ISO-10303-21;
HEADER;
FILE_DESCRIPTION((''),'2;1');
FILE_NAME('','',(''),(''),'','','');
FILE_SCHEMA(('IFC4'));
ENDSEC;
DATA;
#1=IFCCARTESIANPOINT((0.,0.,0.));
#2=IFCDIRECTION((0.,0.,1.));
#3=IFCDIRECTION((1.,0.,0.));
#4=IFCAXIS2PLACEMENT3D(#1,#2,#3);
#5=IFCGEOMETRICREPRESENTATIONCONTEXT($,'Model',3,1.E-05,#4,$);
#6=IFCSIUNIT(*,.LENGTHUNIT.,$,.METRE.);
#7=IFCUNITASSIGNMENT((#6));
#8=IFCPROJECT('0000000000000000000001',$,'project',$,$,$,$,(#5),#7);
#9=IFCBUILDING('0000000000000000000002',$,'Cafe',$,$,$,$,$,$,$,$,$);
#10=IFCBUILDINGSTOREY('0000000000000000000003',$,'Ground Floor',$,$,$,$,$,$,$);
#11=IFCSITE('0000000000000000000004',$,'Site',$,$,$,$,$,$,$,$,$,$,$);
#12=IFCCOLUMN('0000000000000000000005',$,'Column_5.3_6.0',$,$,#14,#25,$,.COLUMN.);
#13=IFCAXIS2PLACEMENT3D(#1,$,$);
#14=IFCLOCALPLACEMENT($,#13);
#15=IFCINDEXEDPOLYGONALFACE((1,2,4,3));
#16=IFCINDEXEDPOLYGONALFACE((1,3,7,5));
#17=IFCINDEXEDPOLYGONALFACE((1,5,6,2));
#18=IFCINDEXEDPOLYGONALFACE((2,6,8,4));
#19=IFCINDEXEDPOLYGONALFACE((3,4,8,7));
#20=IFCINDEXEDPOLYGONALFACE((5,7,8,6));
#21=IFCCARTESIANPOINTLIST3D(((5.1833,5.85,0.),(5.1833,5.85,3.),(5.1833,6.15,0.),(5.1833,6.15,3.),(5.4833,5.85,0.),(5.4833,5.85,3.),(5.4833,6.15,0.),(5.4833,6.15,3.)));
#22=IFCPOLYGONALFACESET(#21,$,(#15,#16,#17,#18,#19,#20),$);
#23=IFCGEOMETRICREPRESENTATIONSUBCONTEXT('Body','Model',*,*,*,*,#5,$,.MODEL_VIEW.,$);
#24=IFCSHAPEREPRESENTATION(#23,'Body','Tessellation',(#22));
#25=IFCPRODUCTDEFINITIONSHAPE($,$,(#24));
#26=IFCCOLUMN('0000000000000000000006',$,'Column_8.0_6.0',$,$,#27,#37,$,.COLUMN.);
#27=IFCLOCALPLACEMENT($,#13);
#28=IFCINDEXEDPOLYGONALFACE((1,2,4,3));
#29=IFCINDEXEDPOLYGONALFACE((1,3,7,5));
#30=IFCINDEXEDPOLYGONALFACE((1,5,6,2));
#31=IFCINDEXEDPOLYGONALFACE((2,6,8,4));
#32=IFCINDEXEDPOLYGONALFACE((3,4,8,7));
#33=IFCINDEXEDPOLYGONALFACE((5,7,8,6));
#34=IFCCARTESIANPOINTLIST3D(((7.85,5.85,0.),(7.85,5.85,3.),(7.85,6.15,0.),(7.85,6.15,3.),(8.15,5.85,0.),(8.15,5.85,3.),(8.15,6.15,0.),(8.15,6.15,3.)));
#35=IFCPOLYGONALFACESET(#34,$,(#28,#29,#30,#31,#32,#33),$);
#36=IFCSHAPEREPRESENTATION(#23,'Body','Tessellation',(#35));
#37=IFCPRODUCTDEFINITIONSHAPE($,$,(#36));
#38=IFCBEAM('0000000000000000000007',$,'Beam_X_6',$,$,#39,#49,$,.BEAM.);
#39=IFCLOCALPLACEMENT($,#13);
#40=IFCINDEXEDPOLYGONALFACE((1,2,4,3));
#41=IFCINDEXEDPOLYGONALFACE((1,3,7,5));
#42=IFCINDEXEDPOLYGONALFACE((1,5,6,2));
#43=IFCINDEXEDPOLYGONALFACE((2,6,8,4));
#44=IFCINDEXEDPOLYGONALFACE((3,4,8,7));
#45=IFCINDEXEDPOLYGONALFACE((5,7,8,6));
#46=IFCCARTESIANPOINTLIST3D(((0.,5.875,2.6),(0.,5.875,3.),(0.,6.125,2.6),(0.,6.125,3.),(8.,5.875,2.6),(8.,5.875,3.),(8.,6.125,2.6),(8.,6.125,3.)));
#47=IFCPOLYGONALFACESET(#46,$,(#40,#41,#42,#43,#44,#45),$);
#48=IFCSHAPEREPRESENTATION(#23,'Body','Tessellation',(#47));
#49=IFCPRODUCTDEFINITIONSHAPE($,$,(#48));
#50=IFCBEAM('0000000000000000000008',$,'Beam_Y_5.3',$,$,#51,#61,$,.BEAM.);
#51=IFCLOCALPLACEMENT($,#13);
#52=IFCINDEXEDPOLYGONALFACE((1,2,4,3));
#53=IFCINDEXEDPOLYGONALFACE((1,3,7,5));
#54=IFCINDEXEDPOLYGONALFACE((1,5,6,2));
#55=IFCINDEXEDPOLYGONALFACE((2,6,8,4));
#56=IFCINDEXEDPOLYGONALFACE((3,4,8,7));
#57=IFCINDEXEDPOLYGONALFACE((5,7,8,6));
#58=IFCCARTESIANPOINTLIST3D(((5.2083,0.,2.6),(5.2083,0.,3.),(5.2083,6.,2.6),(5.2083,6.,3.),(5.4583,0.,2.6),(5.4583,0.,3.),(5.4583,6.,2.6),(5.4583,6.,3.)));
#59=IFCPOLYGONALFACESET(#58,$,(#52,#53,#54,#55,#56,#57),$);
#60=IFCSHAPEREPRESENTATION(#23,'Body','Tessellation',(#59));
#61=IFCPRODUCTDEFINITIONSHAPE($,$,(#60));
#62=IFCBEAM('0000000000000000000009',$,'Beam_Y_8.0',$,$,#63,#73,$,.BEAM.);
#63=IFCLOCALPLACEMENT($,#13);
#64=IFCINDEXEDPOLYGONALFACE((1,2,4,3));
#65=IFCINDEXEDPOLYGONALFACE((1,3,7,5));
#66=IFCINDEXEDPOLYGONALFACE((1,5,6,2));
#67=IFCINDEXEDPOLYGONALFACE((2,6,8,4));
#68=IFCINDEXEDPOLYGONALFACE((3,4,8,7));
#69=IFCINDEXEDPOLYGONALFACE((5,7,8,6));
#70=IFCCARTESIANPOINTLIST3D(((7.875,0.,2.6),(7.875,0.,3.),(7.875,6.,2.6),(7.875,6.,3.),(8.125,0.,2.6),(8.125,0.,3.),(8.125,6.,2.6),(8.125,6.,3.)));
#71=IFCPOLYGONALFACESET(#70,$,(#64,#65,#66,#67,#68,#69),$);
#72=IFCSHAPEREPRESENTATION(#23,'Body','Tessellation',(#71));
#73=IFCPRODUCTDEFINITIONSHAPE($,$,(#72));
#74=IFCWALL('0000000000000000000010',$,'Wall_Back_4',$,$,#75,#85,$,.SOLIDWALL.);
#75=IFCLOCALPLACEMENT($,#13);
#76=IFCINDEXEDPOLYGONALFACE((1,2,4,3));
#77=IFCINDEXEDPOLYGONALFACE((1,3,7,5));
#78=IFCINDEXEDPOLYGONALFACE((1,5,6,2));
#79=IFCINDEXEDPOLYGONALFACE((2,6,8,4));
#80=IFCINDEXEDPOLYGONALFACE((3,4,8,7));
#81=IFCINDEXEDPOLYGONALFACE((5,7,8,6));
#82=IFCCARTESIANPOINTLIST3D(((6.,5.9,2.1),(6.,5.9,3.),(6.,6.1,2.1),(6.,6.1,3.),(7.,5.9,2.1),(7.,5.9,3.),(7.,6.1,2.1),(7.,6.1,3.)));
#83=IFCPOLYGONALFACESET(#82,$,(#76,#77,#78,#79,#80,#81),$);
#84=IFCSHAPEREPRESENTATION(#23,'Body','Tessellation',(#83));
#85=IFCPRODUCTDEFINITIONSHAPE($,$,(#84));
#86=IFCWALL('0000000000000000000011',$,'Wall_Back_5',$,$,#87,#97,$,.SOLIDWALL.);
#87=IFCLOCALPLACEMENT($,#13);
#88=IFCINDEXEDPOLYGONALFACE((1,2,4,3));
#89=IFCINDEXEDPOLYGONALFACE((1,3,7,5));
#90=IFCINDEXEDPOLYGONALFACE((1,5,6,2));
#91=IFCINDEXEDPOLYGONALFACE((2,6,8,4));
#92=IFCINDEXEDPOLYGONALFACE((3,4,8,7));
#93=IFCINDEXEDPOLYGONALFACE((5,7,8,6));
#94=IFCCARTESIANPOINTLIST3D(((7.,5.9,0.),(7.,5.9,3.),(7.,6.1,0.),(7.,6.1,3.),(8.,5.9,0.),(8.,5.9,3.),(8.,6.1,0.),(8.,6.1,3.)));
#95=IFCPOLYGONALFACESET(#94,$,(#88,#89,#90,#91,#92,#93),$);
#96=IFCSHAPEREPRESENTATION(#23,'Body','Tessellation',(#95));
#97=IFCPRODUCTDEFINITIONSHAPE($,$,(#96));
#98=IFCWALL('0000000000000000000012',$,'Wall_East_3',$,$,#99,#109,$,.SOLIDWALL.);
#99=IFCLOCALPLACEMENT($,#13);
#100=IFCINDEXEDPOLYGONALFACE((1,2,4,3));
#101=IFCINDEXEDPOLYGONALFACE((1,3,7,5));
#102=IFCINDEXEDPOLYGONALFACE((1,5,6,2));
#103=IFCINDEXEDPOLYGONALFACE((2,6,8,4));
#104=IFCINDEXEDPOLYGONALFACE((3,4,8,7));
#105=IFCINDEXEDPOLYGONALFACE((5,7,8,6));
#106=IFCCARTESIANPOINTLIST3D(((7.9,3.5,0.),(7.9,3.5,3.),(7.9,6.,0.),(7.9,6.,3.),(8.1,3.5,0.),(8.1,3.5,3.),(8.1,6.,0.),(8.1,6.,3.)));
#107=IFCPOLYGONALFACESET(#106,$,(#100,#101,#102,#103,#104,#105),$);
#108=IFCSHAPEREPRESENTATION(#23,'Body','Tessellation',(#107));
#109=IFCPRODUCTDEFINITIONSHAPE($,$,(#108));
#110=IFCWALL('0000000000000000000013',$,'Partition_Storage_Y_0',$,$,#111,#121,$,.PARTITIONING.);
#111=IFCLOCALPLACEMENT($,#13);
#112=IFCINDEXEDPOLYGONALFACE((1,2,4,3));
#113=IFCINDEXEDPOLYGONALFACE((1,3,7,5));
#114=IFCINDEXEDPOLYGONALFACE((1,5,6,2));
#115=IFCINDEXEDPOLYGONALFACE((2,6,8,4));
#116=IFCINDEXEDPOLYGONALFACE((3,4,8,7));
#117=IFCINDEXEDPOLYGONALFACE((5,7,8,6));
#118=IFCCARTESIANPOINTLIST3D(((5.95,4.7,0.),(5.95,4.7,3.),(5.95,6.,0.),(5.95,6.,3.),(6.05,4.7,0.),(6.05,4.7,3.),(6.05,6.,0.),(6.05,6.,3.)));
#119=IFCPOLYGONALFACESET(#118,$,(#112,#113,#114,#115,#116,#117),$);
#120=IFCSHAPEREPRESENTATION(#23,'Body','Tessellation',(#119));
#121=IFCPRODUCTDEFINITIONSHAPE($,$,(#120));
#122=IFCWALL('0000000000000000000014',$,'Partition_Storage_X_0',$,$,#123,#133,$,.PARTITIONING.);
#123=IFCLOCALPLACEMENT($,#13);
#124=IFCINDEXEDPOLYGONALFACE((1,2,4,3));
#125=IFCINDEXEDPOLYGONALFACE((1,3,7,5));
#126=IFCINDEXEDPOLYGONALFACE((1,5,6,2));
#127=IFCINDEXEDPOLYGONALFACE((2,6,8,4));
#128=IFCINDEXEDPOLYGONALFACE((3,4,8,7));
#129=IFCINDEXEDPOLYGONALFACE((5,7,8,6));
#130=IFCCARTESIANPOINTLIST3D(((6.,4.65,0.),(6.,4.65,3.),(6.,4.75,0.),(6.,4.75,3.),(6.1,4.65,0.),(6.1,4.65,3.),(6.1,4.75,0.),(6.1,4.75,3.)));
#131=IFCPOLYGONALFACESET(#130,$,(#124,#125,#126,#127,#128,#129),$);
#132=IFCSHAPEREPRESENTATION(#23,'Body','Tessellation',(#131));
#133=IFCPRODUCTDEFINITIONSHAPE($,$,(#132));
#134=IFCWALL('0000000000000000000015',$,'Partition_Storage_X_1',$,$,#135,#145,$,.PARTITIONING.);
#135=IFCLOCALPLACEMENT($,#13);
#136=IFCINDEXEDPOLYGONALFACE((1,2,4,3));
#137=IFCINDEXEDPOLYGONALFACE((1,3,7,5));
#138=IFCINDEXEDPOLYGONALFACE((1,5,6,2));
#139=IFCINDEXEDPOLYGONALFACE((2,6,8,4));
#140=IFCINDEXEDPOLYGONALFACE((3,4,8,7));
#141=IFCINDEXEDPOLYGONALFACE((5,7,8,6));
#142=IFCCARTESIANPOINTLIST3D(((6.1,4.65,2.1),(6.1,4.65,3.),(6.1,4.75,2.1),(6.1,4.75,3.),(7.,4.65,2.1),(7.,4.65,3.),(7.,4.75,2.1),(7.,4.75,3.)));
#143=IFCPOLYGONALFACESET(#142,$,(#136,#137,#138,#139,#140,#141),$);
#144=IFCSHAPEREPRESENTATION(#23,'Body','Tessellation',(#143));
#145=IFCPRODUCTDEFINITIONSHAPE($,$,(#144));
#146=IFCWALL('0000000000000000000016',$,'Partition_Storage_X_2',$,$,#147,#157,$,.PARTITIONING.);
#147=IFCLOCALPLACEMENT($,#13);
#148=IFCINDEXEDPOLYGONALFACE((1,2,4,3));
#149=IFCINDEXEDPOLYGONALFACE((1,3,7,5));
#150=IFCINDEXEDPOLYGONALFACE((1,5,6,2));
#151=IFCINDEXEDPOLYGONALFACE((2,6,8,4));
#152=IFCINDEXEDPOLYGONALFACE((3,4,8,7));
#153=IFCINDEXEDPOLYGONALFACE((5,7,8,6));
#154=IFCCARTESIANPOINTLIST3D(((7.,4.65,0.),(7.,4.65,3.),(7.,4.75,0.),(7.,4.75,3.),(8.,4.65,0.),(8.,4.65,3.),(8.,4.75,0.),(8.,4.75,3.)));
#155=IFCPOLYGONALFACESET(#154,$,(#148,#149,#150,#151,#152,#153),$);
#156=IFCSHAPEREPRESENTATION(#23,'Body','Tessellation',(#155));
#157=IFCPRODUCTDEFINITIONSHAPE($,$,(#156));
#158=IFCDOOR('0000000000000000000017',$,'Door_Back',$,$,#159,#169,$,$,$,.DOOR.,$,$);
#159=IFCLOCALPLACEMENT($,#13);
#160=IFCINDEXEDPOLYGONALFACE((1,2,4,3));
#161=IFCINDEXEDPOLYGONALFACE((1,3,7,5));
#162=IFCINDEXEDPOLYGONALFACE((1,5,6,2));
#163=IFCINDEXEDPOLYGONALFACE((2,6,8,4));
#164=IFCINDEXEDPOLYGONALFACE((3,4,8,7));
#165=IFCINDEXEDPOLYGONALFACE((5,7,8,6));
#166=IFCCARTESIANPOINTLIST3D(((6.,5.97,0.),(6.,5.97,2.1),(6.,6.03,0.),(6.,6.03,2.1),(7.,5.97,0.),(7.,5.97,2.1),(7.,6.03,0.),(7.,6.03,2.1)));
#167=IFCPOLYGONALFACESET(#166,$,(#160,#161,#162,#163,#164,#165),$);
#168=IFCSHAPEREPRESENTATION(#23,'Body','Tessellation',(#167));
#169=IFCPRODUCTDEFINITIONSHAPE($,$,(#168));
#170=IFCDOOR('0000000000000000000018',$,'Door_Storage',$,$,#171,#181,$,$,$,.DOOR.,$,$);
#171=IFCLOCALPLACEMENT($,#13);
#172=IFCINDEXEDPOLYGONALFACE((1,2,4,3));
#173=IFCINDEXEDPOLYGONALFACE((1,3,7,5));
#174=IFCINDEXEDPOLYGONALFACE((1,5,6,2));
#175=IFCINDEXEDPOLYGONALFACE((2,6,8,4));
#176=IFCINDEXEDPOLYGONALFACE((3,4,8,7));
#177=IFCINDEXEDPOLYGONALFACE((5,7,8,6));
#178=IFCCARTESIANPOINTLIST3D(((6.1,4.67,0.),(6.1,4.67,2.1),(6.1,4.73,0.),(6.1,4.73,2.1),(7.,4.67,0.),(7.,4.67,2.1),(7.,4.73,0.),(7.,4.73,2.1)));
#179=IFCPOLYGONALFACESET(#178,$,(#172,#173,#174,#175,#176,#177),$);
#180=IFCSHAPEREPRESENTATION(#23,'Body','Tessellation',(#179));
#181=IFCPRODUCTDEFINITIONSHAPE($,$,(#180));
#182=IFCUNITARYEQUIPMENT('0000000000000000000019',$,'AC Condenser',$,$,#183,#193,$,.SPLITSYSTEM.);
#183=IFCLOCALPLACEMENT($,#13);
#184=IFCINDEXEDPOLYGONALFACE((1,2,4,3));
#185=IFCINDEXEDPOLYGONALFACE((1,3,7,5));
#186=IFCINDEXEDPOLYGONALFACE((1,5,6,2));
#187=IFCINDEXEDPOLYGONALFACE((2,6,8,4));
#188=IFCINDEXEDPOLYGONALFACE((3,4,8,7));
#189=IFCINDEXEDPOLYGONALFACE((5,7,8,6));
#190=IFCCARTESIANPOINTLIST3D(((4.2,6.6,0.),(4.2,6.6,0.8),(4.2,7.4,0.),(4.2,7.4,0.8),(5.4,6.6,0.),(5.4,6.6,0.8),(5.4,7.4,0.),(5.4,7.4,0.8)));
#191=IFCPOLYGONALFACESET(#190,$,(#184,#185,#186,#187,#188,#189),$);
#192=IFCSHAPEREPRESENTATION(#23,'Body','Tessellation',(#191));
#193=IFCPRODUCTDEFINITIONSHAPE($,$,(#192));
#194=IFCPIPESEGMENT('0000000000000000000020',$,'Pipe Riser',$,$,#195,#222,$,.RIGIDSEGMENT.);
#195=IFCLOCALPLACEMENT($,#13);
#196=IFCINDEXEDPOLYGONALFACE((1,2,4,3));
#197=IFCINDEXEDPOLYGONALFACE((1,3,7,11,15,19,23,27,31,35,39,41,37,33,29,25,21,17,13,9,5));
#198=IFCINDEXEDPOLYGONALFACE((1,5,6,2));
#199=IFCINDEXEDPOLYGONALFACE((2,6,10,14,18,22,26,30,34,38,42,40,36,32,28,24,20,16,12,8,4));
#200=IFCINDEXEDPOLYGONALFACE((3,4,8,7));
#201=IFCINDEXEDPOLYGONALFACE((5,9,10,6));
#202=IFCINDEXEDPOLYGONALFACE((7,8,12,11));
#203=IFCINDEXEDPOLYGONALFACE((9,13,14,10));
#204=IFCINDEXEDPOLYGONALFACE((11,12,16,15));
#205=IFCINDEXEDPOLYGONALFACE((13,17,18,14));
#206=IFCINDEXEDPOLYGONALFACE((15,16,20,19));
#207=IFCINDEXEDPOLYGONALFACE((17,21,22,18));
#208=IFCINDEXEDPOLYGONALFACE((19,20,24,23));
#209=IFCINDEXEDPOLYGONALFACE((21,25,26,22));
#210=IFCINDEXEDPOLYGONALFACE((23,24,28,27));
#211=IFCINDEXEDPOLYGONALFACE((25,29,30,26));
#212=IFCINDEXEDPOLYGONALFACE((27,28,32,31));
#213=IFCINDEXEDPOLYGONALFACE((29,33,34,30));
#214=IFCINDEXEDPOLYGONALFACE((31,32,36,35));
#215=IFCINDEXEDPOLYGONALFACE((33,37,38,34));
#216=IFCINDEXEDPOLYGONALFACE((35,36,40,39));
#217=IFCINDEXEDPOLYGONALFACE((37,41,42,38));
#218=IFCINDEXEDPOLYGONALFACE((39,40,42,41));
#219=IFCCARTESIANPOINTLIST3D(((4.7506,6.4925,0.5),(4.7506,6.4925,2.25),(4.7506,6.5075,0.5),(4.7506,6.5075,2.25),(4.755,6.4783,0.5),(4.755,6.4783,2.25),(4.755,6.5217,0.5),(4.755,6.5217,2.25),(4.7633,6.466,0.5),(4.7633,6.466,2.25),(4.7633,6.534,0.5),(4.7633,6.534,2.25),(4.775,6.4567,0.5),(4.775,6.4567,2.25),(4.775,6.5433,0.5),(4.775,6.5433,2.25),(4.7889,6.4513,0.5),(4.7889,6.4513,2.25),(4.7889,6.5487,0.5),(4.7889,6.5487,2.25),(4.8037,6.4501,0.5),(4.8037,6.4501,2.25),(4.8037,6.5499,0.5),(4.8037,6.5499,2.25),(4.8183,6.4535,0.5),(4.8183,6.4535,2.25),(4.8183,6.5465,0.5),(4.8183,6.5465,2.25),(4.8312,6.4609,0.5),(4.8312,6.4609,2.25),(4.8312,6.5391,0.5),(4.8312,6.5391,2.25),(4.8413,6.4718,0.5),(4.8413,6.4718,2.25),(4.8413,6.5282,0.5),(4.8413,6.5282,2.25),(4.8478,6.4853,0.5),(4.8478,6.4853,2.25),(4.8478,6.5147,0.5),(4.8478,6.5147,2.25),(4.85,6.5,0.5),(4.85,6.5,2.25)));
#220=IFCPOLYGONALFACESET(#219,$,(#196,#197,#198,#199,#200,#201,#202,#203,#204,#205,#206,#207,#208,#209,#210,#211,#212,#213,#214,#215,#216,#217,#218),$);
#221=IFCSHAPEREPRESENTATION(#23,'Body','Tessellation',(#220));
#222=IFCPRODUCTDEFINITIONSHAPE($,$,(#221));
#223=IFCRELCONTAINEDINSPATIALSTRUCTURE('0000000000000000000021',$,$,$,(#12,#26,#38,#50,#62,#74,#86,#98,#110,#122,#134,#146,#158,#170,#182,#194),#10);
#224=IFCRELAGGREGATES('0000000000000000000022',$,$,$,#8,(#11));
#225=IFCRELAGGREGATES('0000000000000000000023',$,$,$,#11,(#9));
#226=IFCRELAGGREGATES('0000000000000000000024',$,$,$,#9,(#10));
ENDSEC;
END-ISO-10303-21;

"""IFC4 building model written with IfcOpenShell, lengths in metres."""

from ifc_helpers import new_model, si_unit, frame, origin, origin_with_axes, origin_2d, place, context, subcontext, project, spatial, rectangle, circle, extrude, element, save


model = new_model("IFC4")

# Units and contexts
model_context = context("Model", 3, precision=1e-05, world=origin_with_axes())
body_context = subcontext(model_context, "Body", "Model", "MODEL_VIEW")
ifc_project = project(units=[si_unit("LENGTHUNIT", "METRE")], contexts=[model_context])

# Site, building, storey
site = spatial("IfcSite", under=ifc_project, Name="Site")
building = spatial("IfcBuilding", under=site, Name="Cafe")
storey = spatial("IfcBuildingStorey", under=building, Name="Ground Floor")

# Columns
for number, where, z_axis, x_axis, name in (
    (1, (5.3333, 6.0, 0.0), (0.0, 0.0, 1.0), (1.0, 0.0, 0.0), "Column_5.3_6.0"),
    (2, (8.0, 6.0, 0.0), (0.0, 0.0, 1.0), (1.0, 0.0, 0.0), "Column_8.0_6.0"),
):
    element("IfcColumn", number, at=place(None, frame(where, z_axis=z_axis, x_axis=x_axis)), inside=storey, Name=name, PredefinedType="COLUMN", context=body_context, shape_type="SweptSolid", body=[
        extrude(rectangle(XDim=0.3, YDim=0.3, at=origin_2d()), origin(), (0.0, 0.0, 1.0), 3.0),
    ])

# Beams
beam_placement = place(None, frame((4.0, 6.0, 2.6), z_axis=(0.0, 0.0, 1.0), x_axis=(1.0, 0.0, 0.0)))
element("IfcBeam", 3, at=beam_placement, inside=storey, Name="Beam_X_6", PredefinedType="BEAM", context=body_context, shape_type="SweptSolid", body=[
    extrude(rectangle(XDim=8.0, YDim=0.25, at=origin_2d()), origin(), (0.0, 0.0, 1.0), 0.4),
])
for number, where, z_axis, x_axis, name in (
    (4, (5.3333, 3.0, 2.6), (0.0, 0.0, 1.0), (1.0, 0.0, 0.0), "Beam_Y_5.3"),
    (5, (8.0, 3.0, 2.6), (0.0, 0.0, 1.0), (1.0, 0.0, 0.0), "Beam_Y_8.0"),
):
    element("IfcBeam", number, at=place(None, frame(where, z_axis=z_axis, x_axis=x_axis)), inside=storey, Name=name, PredefinedType="BEAM", context=body_context, shape_type="SweptSolid", body=[
        extrude(rectangle(XDim=0.25, YDim=6.0, at=origin_2d()), origin(), (0.0, 0.0, 1.0), 0.4),
    ])

# Walls
wall_1_placement = place(None, frame((6.5, 6.0, 2.1), z_axis=(0.0, 0.0, 1.0), x_axis=(1.0, 0.0, 0.0)))
element("IfcWall", 6, at=wall_1_placement, inside=storey, Name="Wall_Back_4", PredefinedType="SOLIDWALL", context=body_context, shape_type="SweptSolid", body=[
    extrude(rectangle(XDim=1.0, YDim=0.2, at=origin_2d()), origin(), (0.0, 0.0, 1.0), 0.9),
])
wall_2_placement = place(None, frame((7.5, 6.0, 0.0), z_axis=(0.0, 0.0, 1.0), x_axis=(1.0, 0.0, 0.0)))
element("IfcWall", 7, at=wall_2_placement, inside=storey, Name="Wall_Back_5", PredefinedType="SOLIDWALL", context=body_context, shape_type="SweptSolid", body=[
    extrude(rectangle(XDim=1.0, YDim=0.2, at=origin_2d()), origin(), (0.0, 0.0, 1.0), 3.0),
])
wall_3_placement = place(None, frame((8.0, 4.75, 0.0), z_axis=(0.0, 0.0, 1.0), x_axis=(1.0, 0.0, 0.0)))
element("IfcWall", 8, at=wall_3_placement, inside=storey, Name="Wall_East_3", PredefinedType="SOLIDWALL", context=body_context, shape_type="SweptSolid", body=[
    extrude(rectangle(XDim=0.2, YDim=2.5, at=origin_2d()), origin(), (0.0, 0.0, 1.0), 3.0),
])
wall_4_placement = place(None, frame((6.0, 5.35, 0.0), z_axis=(0.0, 0.0, 1.0), x_axis=(1.0, 0.0, 0.0)))
element("IfcWall", 9, at=wall_4_placement, inside=storey, Name="Partition_Storage_Y_0", PredefinedType="PARTITIONING", context=body_context, shape_type="SweptSolid", body=[
    extrude(rectangle(XDim=0.1, YDim=1.3, at=origin_2d()), origin(), (0.0, 0.0, 1.0), 3.0),
])
wall_5_placement = place(None, frame((6.05, 4.7, 0.0), z_axis=(0.0, 0.0, 1.0), x_axis=(1.0, 0.0, 0.0)))
element("IfcWall", 10, at=wall_5_placement, inside=storey, Name="Partition_Storage_X_0", PredefinedType="PARTITIONING", context=body_context, shape_type="SweptSolid", body=[
    extrude(rectangle(XDim=0.1, YDim=0.1, at=origin_2d()), origin(), (0.0, 0.0, 1.0), 3.0),
])
wall_6_placement = place(None, frame((6.55, 4.7, 2.1), z_axis=(0.0, 0.0, 1.0), x_axis=(1.0, 0.0, 0.0)))
element("IfcWall", 11, at=wall_6_placement, inside=storey, Name="Partition_Storage_X_1", PredefinedType="PARTITIONING", context=body_context, shape_type="SweptSolid", body=[
    extrude(rectangle(XDim=0.9, YDim=0.1, at=origin_2d()), origin(), (0.0, 0.0, 1.0), 0.9),
])
wall_7_placement = place(None, frame((7.5, 4.7, 0.0), z_axis=(0.0, 0.0, 1.0), x_axis=(1.0, 0.0, 0.0)))
element("IfcWall", 12, at=wall_7_placement, inside=storey, Name="Partition_Storage_X_2", PredefinedType="PARTITIONING", context=body_context, shape_type="SweptSolid", body=[
    extrude(rectangle(XDim=1.0, YDim=0.1, at=origin_2d()), origin(), (0.0, 0.0, 1.0), 3.0),
])

# Doors
door_1_placement = place(None, frame((6.5, 6.0, 0.0), z_axis=(0.0, 0.0, 1.0), x_axis=(1.0, 0.0, 0.0)))
element("IfcDoor", 13, at=door_1_placement, inside=storey, Name="Door_Back", PredefinedType="DOOR", context=body_context, shape_type="SweptSolid", body=[
    extrude(rectangle(XDim=1.0, YDim=0.06, at=origin_2d()), origin(), (0.0, 0.0, 1.0), 2.1),
])
door_2_placement = place(None, frame((6.55, 4.7, 0.0), z_axis=(0.0, 0.0, 1.0), x_axis=(1.0, 0.0, 0.0)))
element("IfcDoor", 14, at=door_2_placement, inside=storey, Name="Door_Storage", PredefinedType="DOOR", context=body_context, shape_type="SweptSolid", body=[
    extrude(rectangle(XDim=0.9, YDim=0.06, at=origin_2d()), origin(), (0.0, 0.0, 1.0), 2.1),
])

# Unitary equipment
unitary_equipment_placement = place(None, frame((4.8, 7.0, 0.0), z_axis=(0.0, 0.0, 1.0), x_axis=(1.0, 0.0, 0.0)))
element("IfcUnitaryEquipment", 15, at=unitary_equipment_placement, inside=storey, Name="AC Condenser", PredefinedType="SPLITSYSTEM", context=body_context, shape_type="SweptSolid", body=[
    extrude(rectangle(XDim=1.2, YDim=0.8, at=origin_2d()), origin(), (0.0, 0.0, 1.0), 0.8),
])

# Pipe segment
pipe_segment_placement = place(None, frame((4.8, 6.5, 0.5), z_axis=(0.0, 0.0, 1.0), x_axis=(1.0, 0.0, 0.0)))
element("IfcPipeSegment", 16, at=pipe_segment_placement, inside=storey, Name="Pipe Riser", PredefinedType="RIGIDSEGMENT", context=body_context, shape_type="SweptSolid", body=[
    extrude(circle(Radius=0.05, at=origin_2d()), origin(), (0.0, 0.0, 1.0), 1.75),
])

save(model, "model.ifc")
